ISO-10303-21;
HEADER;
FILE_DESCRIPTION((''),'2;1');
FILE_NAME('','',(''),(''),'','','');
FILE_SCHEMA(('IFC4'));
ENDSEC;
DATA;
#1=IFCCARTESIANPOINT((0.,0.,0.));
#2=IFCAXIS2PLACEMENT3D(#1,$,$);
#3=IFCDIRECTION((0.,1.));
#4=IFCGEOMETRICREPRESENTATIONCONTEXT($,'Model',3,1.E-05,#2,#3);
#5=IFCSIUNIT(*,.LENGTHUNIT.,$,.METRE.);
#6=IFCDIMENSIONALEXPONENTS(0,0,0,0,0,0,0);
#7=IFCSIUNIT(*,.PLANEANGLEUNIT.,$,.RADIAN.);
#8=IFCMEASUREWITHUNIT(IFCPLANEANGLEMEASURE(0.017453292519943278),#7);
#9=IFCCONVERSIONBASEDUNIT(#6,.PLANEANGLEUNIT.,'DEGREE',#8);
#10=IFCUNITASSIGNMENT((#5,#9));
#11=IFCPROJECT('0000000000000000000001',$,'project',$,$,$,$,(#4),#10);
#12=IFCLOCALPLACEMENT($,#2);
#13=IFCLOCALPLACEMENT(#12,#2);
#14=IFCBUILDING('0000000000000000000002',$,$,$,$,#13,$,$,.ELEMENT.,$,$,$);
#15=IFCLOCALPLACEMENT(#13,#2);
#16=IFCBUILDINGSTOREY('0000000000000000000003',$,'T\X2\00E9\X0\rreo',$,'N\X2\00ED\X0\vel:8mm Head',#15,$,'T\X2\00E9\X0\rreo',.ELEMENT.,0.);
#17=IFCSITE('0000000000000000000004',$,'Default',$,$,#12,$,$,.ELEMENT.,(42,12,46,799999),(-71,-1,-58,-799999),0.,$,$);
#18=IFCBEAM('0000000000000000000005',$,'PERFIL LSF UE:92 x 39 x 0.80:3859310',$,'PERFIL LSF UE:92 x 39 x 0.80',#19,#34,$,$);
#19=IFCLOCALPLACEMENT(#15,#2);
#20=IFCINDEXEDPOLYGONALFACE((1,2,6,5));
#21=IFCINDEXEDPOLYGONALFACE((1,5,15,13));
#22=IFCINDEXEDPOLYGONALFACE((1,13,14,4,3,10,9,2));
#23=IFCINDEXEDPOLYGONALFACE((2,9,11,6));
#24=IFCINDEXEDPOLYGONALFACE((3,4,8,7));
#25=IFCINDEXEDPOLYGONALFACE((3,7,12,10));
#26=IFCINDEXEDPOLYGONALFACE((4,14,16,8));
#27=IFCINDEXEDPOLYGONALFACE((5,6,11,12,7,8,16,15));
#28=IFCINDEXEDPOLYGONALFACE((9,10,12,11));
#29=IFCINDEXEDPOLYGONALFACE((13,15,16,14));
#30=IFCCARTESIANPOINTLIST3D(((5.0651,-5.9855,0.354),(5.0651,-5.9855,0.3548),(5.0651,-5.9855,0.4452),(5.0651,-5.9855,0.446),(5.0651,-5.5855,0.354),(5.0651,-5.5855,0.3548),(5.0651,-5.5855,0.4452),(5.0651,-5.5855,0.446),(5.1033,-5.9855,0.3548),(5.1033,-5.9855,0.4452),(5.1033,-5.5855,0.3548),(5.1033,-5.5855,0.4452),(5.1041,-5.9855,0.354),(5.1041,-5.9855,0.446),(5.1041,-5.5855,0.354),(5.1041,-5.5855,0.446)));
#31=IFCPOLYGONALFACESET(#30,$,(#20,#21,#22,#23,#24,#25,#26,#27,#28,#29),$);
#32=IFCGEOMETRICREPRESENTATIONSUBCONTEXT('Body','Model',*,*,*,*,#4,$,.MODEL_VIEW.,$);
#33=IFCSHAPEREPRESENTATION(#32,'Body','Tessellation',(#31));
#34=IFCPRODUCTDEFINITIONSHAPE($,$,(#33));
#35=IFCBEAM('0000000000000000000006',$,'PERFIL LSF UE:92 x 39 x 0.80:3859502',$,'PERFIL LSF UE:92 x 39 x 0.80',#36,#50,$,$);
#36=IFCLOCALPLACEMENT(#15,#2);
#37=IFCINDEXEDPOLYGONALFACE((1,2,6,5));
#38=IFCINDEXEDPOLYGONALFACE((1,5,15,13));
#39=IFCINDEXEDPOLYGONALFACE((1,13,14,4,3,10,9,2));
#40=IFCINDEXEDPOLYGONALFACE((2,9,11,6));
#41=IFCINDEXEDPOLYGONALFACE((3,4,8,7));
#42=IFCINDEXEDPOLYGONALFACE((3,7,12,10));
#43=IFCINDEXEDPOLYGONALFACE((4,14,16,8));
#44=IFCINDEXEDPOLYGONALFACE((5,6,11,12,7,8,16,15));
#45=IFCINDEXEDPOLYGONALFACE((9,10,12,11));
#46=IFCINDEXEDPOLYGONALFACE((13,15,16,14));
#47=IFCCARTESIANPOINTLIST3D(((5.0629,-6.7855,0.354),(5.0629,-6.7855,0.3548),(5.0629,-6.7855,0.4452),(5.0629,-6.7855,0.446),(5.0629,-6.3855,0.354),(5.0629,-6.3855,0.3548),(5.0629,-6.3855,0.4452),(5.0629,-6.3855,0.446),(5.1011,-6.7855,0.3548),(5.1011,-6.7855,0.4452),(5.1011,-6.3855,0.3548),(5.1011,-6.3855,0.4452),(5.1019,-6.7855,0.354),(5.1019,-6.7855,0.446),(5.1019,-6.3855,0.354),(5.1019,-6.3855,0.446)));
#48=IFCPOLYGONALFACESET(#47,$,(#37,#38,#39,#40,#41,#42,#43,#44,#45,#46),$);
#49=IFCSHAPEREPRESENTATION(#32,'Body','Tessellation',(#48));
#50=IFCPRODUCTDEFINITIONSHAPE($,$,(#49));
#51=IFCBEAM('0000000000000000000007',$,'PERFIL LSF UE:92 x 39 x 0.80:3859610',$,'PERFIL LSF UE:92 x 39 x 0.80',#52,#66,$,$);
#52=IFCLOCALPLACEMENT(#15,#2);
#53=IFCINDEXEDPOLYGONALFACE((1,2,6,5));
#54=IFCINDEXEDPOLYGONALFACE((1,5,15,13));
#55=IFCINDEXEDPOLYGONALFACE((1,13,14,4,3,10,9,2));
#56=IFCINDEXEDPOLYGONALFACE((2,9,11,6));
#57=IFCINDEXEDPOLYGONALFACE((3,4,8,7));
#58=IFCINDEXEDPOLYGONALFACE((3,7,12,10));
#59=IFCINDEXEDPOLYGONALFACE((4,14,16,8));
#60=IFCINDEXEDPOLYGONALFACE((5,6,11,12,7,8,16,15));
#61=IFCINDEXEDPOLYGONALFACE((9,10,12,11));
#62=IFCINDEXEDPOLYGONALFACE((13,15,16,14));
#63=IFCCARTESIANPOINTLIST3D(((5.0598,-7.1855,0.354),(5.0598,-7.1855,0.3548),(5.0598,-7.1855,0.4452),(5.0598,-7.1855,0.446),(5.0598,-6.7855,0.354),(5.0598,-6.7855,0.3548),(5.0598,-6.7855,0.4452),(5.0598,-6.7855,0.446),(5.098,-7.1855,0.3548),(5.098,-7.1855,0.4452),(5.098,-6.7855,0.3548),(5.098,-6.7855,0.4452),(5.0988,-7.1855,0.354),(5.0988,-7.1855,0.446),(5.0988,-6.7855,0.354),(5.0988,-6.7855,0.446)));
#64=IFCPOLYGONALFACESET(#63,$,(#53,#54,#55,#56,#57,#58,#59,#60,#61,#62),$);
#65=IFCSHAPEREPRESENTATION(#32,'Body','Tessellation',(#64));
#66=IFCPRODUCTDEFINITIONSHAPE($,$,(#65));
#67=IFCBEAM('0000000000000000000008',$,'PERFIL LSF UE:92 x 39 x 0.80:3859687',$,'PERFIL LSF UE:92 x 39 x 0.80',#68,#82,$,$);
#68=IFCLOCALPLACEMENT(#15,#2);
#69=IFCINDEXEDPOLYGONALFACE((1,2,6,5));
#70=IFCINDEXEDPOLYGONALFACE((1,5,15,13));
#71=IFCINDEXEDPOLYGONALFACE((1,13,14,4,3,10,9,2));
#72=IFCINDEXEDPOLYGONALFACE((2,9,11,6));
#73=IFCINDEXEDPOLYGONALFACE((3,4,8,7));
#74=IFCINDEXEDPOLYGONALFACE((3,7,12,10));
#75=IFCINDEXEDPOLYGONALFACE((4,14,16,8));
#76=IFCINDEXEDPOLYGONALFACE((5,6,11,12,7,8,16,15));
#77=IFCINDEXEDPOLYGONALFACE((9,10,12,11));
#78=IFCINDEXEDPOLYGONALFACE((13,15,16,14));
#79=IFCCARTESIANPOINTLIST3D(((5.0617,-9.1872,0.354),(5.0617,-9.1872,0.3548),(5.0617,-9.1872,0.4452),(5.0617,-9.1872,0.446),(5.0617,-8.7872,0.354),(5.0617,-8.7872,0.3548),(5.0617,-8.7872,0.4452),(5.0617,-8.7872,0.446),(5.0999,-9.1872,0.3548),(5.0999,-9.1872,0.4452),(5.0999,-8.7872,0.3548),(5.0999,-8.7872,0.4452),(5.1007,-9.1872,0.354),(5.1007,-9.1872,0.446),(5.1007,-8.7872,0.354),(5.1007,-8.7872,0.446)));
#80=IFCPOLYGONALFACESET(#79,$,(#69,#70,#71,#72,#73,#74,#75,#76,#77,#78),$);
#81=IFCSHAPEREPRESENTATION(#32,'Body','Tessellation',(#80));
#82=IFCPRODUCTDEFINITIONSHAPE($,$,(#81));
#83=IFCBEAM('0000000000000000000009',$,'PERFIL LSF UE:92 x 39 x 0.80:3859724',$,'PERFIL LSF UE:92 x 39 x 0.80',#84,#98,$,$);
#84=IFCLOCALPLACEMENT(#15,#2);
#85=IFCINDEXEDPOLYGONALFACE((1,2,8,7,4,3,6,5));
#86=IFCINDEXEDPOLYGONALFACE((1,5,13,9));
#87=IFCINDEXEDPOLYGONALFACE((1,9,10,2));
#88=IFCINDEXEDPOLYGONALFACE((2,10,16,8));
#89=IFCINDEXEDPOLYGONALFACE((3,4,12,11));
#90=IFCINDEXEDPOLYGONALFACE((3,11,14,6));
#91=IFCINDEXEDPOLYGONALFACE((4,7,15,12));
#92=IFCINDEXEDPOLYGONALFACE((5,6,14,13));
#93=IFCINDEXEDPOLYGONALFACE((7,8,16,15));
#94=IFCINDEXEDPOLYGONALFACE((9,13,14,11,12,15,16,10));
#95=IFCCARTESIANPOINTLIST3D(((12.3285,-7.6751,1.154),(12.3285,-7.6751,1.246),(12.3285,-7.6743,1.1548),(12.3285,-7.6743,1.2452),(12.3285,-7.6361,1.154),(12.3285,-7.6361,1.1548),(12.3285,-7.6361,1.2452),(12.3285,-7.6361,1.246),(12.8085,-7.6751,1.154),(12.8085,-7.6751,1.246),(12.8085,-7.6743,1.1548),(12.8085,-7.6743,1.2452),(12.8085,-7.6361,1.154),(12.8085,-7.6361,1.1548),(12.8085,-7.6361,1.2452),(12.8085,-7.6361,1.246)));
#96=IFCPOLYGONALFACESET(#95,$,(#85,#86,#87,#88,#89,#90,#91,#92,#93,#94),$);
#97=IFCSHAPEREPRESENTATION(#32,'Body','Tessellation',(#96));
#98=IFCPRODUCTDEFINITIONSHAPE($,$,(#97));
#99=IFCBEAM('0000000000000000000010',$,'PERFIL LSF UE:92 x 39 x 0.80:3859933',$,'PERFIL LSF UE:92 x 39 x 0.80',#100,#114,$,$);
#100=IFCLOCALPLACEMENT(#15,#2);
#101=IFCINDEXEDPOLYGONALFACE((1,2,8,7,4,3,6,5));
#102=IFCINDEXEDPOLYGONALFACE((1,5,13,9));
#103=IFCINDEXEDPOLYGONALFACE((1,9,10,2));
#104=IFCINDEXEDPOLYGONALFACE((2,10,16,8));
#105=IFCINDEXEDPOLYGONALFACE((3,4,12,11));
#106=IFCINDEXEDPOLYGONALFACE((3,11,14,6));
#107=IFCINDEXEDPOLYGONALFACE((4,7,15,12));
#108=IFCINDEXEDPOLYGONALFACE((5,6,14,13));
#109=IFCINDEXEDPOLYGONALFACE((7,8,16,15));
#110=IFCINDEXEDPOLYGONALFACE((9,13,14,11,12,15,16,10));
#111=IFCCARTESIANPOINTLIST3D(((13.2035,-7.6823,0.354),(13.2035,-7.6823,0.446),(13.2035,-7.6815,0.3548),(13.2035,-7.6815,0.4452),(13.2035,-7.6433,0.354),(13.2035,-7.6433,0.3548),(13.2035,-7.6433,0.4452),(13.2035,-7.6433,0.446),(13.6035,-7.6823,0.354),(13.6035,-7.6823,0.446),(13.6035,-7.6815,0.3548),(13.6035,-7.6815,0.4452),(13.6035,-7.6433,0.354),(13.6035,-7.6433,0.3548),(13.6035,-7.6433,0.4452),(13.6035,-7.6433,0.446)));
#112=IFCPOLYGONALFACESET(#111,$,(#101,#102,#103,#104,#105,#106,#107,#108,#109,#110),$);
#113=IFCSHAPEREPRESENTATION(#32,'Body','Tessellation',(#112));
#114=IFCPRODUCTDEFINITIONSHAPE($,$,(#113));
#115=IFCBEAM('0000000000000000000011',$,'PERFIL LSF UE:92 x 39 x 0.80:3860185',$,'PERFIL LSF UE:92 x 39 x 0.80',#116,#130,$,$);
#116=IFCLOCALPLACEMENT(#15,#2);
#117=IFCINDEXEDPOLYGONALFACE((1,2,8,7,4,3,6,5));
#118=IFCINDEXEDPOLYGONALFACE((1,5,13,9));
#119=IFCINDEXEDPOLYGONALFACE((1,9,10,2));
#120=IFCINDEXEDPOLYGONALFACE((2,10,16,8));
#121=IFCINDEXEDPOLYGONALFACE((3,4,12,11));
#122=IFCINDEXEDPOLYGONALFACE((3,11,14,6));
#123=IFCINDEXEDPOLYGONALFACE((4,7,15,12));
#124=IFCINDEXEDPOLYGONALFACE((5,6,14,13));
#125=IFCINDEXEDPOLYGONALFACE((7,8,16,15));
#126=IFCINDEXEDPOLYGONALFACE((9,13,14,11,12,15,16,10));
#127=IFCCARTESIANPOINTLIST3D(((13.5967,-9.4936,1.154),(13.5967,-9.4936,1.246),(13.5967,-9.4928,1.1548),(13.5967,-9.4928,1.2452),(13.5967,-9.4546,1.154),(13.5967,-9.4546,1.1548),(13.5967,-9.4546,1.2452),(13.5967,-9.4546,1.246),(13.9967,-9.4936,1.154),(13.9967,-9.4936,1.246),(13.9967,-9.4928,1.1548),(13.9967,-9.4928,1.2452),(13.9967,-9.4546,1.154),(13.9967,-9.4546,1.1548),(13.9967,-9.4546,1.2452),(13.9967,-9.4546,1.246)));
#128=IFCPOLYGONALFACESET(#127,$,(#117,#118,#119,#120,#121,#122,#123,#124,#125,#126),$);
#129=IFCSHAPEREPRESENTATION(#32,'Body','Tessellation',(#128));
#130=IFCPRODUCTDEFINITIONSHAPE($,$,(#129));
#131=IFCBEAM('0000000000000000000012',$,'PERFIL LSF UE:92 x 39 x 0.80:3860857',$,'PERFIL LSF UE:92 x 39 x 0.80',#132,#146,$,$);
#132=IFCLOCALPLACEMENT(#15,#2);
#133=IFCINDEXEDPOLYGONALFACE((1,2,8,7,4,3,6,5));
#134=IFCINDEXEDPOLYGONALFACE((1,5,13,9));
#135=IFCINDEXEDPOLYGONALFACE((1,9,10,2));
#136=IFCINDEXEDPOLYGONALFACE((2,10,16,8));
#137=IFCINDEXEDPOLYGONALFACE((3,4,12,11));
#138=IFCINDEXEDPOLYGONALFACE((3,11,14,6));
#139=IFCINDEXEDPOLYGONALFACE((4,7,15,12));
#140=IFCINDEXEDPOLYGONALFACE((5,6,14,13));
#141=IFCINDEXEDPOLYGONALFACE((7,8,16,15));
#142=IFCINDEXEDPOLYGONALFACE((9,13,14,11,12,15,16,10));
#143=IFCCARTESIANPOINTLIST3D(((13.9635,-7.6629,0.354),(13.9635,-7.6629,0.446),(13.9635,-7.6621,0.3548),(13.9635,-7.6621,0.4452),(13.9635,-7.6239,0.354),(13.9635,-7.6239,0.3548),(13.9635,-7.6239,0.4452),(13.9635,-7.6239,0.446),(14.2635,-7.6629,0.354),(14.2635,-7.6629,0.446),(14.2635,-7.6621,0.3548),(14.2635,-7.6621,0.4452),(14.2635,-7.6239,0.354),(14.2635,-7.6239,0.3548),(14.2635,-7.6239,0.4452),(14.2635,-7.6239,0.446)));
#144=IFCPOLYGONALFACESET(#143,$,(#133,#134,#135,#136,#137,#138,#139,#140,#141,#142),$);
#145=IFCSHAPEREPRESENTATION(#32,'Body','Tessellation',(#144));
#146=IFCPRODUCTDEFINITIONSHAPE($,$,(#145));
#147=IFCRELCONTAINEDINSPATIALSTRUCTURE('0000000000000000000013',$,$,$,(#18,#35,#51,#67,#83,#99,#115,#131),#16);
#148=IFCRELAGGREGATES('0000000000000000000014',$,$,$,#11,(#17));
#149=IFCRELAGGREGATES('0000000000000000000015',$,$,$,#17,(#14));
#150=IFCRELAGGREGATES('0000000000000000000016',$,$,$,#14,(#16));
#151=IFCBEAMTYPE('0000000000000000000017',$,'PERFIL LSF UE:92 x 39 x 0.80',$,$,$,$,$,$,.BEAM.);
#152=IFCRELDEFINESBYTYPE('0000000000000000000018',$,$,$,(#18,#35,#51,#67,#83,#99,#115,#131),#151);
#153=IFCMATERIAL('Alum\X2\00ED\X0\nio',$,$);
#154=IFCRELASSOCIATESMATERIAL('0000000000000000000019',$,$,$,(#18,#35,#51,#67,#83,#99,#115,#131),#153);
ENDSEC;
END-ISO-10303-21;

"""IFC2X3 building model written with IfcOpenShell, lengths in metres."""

from ifc_helpers import new_model, entity, si_unit, converted_unit, direction, frame, origin, place, context, subcontext, project, spatial, polyline, outline, extrude, material, type_object, element, save


model = new_model("IFC2X3")

# Units and contexts
model_context = context("Model", 3, precision=1e-05, world=origin(), true_north=direction((0.0, 1.0)))
body_context = subcontext(model_context, "Body", "Model", "MODEL_VIEW")
ifc_project = project(units=[si_unit("LENGTHUNIT", "METRE"), converted_unit("PLANEANGLEUNIT", "DEGREE", entity("IfcPlaneAngleMeasure", 0.017453292519943278), si_unit("PLANEANGLEUNIT", "RADIAN"), dimensions=[0, 0, 0, 0, 0, 0, 0])], contexts=[model_context])

# Site, building, storey
site_placement = place(None, origin())
site = spatial("IfcSite", under=ifc_project, at=site_placement, Name="Default", CompositionType="ELEMENT", RefLatitude=(42, 12, 46, 799999), RefLongitude=(-71, -1, -58, -799999), RefElevation=0.0)
building_placement = place(site_placement, origin())
building = spatial("IfcBuilding", under=site, at=building_placement, CompositionType="ELEMENT")
storey_placement = place(building_placement, origin())
storey = spatial("IfcBuildingStorey", under=building, at=storey_placement, Name="Térreo", ObjectType="Nível:8mm Head", LongName="Térreo", CompositionType="ELEMENT", Elevation=0.0)

# Beams
ifc_material_1 = material(Name="Alumínio")
beam_type = type_object("IfcBeamType", Name="PERFIL LSF UE:92 x 39 x 0.80", PredefinedType="BEAM")
beam_1_placement = place(storey_placement, frame((5.4651, -5.5855, 0.0), z_axis=(0.0, 0.0, 1.0), x_axis=(0.0, -1.0, 0.0)))
element("IfcBeam", 1, at=beam_1_placement, inside=storey, type_object=beam_type, material=ifc_material_1, Name="PERFIL LSF UE:92 x 39 x 0.80:3859310", ObjectType="PERFIL LSF UE:92 x 39 x 0.80", context=body_context, shape_type="SweptSolid", body=[
    extrude(outline(polyline([(-0.046, -0.0193), (-0.0452, -0.0193), (-0.0452, 0.0189), (0.0452, 0.0189), (0.0452, -0.0193), (0.046, -0.0193), (0.046, 0.0197), (-0.046, 0.0197), (-0.046, -0.0193)])), frame((0.0, -0.3807, 0.4), z_axis=(1.0, 0.0, 0.0), x_axis=(0.0, 0.0, -1.0)), (0.0, 0.0, 1.0), 0.4),
])
beam_2_placement = place(storey_placement, frame((5.4629, -6.3855, 0.0), z_axis=(0.0, 0.0, 1.0), x_axis=(0.0, -1.0, 0.0)))
element("IfcBeam", 2, at=beam_2_placement, inside=storey, type_object=beam_type, material=ifc_material_1, Name="PERFIL LSF UE:92 x 39 x 0.80:3859502", ObjectType="PERFIL LSF UE:92 x 39 x 0.80", context=body_context, shape_type="SweptSolid", body=[
    extrude(outline(polyline([(-0.046, -0.0193), (-0.0452, -0.0193), (-0.0452, 0.0189), (0.0452, 0.0189), (0.0452, -0.0193), (0.046, -0.0193), (0.046, 0.0197), (-0.046, 0.0197), (-0.046, -0.0193)])), frame((0.0, -0.3807, 0.4), z_axis=(1.0, 0.0, 0.0), x_axis=(0.0, 0.0, -1.0)), (0.0, 0.0, 1.0), 0.4),
])
beam_3_placement = place(storey_placement, frame((5.4598, -6.7855, 0.0), z_axis=(0.0, 0.0, 1.0), x_axis=(0.0, -1.0, 0.0)))
element("IfcBeam", 3, at=beam_3_placement, inside=storey, type_object=beam_type, material=ifc_material_1, Name="PERFIL LSF UE:92 x 39 x 0.80:3859610", ObjectType="PERFIL LSF UE:92 x 39 x 0.80", context=body_context, shape_type="SweptSolid", body=[
    extrude(outline(polyline([(-0.046, -0.0193), (-0.0452, -0.0193), (-0.0452, 0.0189), (0.0452, 0.0189), (0.0452, -0.0193), (0.046, -0.0193), (0.046, 0.0197), (-0.046, 0.0197), (-0.046, -0.0193)])), frame((0.0, -0.3807, 0.4), z_axis=(1.0, 0.0, 0.0), x_axis=(0.0, 0.0, -1.0)), (0.0, 0.0, 1.0), 0.4),
])
beam_4_placement = place(storey_placement, frame((5.4617, -8.7872, 0.0), z_axis=(0.0, 0.0, 1.0), x_axis=(0.0, -1.0, 0.0)))
element("IfcBeam", 4, at=beam_4_placement, inside=storey, type_object=beam_type, material=ifc_material_1, Name="PERFIL LSF UE:92 x 39 x 0.80:3859687", ObjectType="PERFIL LSF UE:92 x 39 x 0.80", context=body_context, shape_type="SweptSolid", body=[
    extrude(outline(polyline([(-0.046, -0.0193), (-0.0452, -0.0193), (-0.0452, 0.0189), (0.0452, 0.0189), (0.0452, -0.0193), (0.046, -0.0193), (0.046, 0.0197), (-0.046, 0.0197), (-0.046, -0.0193)])), frame((0.0, -0.3807, 0.4), z_axis=(1.0, 0.0, 0.0), x_axis=(0.0, 0.0, -1.0)), (0.0, 0.0, 1.0), 0.4),
])
beam_5_placement = place(storey_placement, frame((12.8085, -8.0361, 0.0), z_axis=(0.0, 0.0, 1.0), x_axis=(-1.0, 0.0, 0.0)))
element("IfcBeam", 5, at=beam_5_placement, inside=storey, type_object=beam_type, material=ifc_material_1, Name="PERFIL LSF UE:92 x 39 x 0.80:3859724", ObjectType="PERFIL LSF UE:92 x 39 x 0.80", context=body_context, shape_type="SweptSolid", body=[
    extrude(outline(polyline([(-0.046, -0.0193), (-0.0452, -0.0193), (-0.0452, 0.0189), (0.0452, 0.0189), (0.0452, -0.0193), (0.046, -0.0193), (0.046, 0.0197), (-0.046, 0.0197), (-0.046, -0.0193)])), frame((0.0, -0.3807, 1.2), z_axis=(1.0, 0.0, 0.0), x_axis=(0.0, 0.0, -1.0)), (0.0, 0.0, 1.0), 0.48),
])
beam_6_placement = place(storey_placement, frame((13.6035, -8.0433, 0.0), z_axis=(0.0, 0.0, 1.0), x_axis=(-1.0, 0.0, 0.0)))
element("IfcBeam", 6, at=beam_6_placement, inside=storey, type_object=beam_type, material=ifc_material_1, Name="PERFIL LSF UE:92 x 39 x 0.80:3859933", ObjectType="PERFIL LSF UE:92 x 39 x 0.80", context=body_context, shape_type="SweptSolid", body=[
    extrude(outline(polyline([(-0.046, -0.0193), (-0.0452, -0.0193), (-0.0452, 0.0189), (0.0452, 0.0189), (0.0452, -0.0193), (0.046, -0.0193), (0.046, 0.0197), (-0.046, 0.0197), (-0.046, -0.0193)])), frame((0.0, -0.3807, 0.4), z_axis=(1.0, 0.0, 0.0), x_axis=(0.0, 0.0, -1.0)), (0.0, 0.0, 1.0), 0.4),
])
for number, where, z_axis, x_axis, name in (
    (7, (13.9967, -9.8546, 0.0), (0.0, 0.0, 1.0), (-1.0, 0.0, 0.0), "PERFIL LSF UE:92 x 39 x 0.80:3860185"),
):
    element("IfcBeam", number, at=place(storey_placement, frame(where, z_axis=z_axis, x_axis=x_axis)), inside=storey, type_object=beam_type, material=ifc_material_1, Name=name, ObjectType="PERFIL LSF UE:92 x 39 x 0.80", context=body_context, shape_type="SweptSolid", body=[
        extrude(outline(polyline([(-0.046, -0.0193), (-0.0452, -0.0193), (-0.0452, 0.0189), (0.0452, 0.0189), (0.0452, -0.0193), (0.046, -0.0193), (0.046, 0.0197), (-0.046, 0.0197), (-0.046, -0.0193)])), frame((0.0, -0.3807, 1.2), z_axis=(1.0, 0.0, 0.0), x_axis=(0.0, 0.0, -1.0)), (0.0, 0.0, 1.0), 0.4),
    ])
beam_7_placement = place(storey_placement, frame((14.2635, -8.0239, 0.0), z_axis=(0.0, 0.0, 1.0), x_axis=(-1.0, 0.0, 0.0)))
element("IfcBeam", 8, at=beam_7_placement, inside=storey, type_object=beam_type, material=ifc_material_1, Name="PERFIL LSF UE:92 x 39 x 0.80:3860857", ObjectType="PERFIL LSF UE:92 x 39 x 0.80", context=body_context, shape_type="SweptSolid", body=[
    extrude(outline(polyline([(-0.046, -0.0193), (-0.0452, -0.0193), (-0.0452, 0.0189), (0.0452, 0.0189), (0.0452, -0.0193), (0.046, -0.0193), (0.046, 0.0197), (-0.046, 0.0197), (-0.046, -0.0193)])), frame((0.0, -0.3807, 0.4), z_axis=(1.0, 0.0, 0.0), x_axis=(0.0, 0.0, -1.0)), (0.0, 0.0, 1.0), 0.3),
])

save(model, "model.ifc")
